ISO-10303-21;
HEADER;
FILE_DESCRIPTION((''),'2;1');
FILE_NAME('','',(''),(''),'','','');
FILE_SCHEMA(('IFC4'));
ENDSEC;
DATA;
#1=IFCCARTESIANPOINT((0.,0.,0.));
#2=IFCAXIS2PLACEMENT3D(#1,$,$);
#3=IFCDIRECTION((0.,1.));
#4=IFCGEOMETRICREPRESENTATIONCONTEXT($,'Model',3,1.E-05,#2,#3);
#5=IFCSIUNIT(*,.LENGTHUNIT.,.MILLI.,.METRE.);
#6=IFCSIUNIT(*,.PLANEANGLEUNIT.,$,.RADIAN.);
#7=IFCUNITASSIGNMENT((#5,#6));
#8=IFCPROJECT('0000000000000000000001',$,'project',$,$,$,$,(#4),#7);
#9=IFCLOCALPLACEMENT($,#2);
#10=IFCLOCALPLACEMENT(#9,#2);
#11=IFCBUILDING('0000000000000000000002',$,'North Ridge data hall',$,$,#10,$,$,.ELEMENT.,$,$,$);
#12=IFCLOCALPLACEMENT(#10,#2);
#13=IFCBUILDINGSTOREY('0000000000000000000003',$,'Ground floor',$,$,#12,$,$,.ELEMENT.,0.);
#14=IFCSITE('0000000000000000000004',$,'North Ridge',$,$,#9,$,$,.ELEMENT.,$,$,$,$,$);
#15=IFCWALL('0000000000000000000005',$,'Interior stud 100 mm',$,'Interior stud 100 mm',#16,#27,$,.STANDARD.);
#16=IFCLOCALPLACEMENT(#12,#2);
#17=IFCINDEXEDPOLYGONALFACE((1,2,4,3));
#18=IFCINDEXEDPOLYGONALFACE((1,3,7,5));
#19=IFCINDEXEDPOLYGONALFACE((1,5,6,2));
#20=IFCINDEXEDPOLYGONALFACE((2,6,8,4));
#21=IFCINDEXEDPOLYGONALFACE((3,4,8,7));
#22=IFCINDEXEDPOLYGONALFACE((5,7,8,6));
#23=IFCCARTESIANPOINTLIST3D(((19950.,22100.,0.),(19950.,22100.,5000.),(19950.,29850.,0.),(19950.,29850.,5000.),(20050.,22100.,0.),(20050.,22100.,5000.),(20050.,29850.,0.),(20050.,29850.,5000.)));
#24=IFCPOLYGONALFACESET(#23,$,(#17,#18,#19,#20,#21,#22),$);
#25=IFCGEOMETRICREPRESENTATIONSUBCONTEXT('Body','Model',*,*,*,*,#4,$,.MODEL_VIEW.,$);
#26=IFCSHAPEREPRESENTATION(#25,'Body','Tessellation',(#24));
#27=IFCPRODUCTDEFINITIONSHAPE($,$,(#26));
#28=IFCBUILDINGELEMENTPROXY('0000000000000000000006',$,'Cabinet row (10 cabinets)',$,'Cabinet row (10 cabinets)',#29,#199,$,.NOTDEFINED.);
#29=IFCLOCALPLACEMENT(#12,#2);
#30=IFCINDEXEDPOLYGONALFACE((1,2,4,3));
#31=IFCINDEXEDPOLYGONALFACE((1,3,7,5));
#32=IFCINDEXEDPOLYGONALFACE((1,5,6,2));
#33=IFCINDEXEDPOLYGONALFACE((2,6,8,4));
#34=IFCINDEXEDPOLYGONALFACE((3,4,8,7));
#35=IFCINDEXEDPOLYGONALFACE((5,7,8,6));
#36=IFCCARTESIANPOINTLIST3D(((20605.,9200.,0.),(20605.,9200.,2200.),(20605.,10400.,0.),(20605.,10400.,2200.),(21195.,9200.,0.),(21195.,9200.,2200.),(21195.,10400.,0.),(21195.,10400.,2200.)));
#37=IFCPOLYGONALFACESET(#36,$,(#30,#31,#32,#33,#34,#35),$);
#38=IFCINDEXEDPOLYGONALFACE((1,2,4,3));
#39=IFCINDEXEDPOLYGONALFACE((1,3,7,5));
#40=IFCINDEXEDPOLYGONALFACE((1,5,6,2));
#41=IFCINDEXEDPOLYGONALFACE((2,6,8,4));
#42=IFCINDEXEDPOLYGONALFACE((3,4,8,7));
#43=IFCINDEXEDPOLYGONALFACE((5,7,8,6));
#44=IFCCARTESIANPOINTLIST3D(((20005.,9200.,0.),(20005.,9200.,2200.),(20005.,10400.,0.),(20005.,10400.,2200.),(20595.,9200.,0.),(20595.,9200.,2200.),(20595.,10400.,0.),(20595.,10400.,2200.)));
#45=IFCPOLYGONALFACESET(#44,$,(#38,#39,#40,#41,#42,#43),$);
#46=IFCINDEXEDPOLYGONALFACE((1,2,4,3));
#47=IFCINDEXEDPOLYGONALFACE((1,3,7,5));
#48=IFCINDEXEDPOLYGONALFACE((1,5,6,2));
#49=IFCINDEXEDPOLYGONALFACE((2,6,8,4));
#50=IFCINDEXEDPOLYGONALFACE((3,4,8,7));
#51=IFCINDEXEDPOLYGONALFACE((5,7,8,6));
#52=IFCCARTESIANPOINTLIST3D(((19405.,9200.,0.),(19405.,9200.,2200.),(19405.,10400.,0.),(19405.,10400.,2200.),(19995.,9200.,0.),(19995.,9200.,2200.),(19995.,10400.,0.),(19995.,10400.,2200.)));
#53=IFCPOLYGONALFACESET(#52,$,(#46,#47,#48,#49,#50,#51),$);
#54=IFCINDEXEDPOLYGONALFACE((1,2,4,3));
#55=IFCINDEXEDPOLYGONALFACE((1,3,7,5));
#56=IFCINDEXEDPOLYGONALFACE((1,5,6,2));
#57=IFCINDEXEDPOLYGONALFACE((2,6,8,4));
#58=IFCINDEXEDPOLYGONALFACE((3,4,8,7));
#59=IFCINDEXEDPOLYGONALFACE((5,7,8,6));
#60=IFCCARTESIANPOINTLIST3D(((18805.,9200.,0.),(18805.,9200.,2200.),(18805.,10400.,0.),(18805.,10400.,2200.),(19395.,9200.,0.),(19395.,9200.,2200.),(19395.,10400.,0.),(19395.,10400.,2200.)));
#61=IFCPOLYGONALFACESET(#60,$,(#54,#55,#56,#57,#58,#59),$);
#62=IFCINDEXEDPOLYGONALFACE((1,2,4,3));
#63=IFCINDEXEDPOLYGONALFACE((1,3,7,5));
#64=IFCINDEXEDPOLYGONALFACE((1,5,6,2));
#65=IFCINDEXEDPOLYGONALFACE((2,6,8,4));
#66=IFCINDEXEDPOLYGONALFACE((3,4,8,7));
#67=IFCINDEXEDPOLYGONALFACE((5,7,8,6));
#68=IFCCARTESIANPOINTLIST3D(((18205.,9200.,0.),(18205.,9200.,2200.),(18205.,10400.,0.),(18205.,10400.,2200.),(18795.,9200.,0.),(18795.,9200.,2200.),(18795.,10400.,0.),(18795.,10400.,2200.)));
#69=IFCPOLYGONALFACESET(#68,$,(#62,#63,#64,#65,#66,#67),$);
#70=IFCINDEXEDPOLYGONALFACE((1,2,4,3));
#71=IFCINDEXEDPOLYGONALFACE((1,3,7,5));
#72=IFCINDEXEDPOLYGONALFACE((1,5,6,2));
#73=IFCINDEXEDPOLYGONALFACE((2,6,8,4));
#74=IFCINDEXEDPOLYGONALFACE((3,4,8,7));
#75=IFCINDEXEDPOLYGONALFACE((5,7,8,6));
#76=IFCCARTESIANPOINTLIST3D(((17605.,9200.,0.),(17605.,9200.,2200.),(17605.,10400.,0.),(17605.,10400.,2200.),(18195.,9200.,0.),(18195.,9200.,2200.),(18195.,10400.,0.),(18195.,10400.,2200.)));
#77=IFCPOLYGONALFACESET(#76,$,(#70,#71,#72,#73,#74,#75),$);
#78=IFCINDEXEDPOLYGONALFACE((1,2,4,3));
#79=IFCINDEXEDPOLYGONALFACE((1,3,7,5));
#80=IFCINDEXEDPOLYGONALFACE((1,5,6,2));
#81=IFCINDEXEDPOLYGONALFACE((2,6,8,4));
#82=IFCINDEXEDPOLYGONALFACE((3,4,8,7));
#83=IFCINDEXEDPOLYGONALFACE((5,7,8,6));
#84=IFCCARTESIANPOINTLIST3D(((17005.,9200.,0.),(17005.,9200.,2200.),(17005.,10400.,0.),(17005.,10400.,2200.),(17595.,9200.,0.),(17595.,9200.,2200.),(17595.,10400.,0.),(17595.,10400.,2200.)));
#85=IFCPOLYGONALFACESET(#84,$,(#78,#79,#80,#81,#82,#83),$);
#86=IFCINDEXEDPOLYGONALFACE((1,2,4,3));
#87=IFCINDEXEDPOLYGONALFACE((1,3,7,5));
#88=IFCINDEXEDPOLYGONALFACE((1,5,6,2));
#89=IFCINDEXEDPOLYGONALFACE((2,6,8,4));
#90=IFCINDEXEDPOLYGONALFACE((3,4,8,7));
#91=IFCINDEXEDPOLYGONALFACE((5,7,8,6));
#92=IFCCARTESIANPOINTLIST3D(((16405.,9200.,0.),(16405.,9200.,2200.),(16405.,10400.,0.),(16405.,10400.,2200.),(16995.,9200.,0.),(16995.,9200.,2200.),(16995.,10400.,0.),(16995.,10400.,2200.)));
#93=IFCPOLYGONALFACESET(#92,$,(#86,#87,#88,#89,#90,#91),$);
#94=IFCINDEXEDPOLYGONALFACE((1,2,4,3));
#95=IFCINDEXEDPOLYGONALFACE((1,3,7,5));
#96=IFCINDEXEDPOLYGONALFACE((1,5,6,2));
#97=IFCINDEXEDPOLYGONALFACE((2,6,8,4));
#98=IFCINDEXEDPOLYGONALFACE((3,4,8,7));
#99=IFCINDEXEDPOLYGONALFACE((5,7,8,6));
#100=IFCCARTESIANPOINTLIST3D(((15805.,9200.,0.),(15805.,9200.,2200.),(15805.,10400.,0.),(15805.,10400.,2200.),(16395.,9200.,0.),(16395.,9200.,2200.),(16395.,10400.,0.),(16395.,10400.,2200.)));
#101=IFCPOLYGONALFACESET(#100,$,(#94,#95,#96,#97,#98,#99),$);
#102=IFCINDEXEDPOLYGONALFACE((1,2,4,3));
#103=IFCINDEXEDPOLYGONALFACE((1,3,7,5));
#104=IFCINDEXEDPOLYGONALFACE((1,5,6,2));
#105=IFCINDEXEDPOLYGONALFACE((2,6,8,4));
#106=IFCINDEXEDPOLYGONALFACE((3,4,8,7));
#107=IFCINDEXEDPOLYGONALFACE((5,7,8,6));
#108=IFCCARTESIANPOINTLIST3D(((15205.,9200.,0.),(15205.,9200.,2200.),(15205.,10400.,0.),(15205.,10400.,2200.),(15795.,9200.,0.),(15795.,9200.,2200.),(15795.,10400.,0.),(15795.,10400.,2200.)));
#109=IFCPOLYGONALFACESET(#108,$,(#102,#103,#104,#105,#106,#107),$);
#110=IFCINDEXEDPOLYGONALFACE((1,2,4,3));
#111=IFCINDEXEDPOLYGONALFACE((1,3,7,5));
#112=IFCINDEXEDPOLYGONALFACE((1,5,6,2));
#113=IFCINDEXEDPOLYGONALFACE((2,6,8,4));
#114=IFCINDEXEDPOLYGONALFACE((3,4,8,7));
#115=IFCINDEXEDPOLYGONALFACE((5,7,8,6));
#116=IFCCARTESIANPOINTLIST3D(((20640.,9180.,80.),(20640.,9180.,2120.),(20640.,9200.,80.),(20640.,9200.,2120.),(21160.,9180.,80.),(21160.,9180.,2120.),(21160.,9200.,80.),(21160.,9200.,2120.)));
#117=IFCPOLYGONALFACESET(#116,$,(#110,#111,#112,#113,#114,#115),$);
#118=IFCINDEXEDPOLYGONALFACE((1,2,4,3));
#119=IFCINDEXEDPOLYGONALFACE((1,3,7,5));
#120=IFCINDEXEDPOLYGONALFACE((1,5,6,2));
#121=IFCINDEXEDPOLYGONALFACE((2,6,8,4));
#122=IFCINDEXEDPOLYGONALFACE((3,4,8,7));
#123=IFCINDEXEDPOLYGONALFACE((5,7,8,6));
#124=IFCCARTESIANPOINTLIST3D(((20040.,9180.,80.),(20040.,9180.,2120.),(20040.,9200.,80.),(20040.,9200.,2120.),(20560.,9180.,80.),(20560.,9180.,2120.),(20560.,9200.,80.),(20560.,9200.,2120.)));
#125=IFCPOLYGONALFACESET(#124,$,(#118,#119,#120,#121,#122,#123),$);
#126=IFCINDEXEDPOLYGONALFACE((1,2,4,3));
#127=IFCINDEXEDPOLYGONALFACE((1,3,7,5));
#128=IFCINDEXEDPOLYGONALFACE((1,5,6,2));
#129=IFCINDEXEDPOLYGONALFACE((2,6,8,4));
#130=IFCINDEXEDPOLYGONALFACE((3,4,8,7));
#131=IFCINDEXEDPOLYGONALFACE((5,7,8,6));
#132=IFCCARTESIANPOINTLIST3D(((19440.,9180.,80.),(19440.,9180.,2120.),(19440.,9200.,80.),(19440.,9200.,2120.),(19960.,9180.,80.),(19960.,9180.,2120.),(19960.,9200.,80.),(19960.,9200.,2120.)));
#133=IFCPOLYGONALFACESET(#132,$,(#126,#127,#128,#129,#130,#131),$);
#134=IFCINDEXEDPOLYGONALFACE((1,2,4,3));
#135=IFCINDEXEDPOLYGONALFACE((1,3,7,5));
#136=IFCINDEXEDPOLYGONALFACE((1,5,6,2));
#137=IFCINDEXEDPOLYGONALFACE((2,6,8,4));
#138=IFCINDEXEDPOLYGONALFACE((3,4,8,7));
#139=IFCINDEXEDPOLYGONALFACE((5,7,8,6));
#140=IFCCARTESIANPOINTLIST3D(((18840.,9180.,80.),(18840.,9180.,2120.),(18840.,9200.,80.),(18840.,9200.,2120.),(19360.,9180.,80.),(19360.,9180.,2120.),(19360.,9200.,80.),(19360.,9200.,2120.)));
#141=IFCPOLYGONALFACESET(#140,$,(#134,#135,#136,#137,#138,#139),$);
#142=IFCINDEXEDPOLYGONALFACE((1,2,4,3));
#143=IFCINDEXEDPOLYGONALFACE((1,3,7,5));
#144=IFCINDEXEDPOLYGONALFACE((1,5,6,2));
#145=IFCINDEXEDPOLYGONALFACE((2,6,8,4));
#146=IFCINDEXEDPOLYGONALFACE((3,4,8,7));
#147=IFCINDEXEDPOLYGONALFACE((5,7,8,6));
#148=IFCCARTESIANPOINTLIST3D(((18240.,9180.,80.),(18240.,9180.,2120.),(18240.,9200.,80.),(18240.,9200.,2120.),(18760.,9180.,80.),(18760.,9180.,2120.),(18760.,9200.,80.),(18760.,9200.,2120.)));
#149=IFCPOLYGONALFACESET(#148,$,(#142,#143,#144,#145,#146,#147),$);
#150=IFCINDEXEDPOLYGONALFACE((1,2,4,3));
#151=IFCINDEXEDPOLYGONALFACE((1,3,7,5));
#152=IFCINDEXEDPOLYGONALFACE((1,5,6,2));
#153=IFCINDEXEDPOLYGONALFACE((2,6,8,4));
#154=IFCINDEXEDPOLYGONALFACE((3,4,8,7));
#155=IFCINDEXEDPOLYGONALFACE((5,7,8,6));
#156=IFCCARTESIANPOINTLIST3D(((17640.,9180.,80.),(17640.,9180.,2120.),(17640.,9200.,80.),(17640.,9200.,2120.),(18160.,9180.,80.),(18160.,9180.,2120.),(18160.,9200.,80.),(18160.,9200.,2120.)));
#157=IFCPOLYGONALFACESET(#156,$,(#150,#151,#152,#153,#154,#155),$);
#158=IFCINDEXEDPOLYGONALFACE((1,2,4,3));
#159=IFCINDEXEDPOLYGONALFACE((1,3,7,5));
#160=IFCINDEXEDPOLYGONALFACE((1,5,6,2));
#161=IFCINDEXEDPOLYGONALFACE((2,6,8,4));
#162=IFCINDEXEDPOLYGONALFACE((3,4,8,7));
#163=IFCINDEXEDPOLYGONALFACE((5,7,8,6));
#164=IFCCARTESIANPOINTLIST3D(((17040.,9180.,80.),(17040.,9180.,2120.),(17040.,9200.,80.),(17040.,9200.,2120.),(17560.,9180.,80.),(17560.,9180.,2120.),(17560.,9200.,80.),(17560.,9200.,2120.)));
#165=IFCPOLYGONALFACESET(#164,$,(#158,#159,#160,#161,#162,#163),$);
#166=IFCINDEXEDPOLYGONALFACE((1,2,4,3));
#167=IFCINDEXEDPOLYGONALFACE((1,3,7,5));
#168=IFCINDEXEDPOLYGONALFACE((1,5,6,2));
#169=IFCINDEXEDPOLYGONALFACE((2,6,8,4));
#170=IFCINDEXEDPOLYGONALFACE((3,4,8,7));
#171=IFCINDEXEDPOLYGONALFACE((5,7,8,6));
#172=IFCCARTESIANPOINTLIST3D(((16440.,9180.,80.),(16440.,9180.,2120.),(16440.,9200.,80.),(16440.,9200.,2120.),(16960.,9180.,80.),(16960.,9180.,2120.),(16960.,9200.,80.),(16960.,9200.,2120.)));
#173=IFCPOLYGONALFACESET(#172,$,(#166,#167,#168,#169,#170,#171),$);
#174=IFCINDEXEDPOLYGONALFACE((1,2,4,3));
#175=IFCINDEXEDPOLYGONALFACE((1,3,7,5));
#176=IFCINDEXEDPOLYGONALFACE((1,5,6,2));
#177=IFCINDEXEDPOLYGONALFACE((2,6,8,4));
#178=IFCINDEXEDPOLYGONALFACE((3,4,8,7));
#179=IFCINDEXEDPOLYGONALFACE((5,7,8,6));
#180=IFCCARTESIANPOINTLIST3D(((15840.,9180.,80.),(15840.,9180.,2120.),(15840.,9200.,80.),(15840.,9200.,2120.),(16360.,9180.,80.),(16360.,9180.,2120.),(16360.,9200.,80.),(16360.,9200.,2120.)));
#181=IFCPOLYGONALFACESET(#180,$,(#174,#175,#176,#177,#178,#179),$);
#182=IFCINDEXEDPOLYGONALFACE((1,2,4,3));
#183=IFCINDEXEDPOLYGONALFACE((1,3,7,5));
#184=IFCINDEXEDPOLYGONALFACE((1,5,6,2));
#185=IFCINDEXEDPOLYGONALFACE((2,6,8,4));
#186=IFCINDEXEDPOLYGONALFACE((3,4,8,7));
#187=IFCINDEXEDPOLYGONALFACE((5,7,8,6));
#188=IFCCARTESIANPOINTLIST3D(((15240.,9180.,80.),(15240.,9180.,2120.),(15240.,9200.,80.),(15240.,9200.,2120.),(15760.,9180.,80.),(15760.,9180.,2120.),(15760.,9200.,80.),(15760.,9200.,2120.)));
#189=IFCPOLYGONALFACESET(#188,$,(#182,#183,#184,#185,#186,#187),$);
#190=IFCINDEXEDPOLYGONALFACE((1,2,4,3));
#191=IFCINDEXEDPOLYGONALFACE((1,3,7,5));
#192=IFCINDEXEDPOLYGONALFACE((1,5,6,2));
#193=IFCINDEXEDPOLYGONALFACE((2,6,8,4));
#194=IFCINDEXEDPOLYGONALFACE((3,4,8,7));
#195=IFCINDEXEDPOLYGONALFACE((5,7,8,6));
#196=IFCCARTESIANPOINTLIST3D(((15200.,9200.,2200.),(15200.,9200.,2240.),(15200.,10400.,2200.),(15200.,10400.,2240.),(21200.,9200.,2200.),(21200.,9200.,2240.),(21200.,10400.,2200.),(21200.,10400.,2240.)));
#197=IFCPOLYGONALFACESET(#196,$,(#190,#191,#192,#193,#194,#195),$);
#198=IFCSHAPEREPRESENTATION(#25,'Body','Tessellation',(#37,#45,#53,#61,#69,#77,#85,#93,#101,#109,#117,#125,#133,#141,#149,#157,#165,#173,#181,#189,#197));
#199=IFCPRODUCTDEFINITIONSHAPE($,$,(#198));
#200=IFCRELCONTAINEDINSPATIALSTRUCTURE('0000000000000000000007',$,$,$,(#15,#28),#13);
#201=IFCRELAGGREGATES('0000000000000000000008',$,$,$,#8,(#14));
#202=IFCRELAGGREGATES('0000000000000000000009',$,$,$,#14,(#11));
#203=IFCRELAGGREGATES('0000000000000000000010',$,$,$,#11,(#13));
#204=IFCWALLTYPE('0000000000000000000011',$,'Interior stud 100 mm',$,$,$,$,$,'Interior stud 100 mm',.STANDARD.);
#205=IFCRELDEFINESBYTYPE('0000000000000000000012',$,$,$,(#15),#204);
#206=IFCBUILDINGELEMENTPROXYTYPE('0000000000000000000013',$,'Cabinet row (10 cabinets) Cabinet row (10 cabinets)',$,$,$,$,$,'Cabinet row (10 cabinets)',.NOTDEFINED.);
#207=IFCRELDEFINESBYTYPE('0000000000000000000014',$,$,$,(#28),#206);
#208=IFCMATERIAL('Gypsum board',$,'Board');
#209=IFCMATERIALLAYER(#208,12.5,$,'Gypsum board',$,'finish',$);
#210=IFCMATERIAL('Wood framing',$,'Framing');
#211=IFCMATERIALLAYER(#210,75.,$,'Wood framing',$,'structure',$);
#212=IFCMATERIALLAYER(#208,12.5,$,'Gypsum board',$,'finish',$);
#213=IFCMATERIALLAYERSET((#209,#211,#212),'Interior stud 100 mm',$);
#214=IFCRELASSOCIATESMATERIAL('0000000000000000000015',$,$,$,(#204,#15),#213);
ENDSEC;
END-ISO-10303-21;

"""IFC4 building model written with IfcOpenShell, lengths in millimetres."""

from ifc_helpers import new_model, si_unit, direction, frame, origin, place, context, subcontext, project, spatial, polyline, outline, extrude, source, transform, mapped, material, layer, layer_set, layer_usage, type_object, type_shapes, element, save


model = new_model("IFC4")

# Units and contexts
model_context = context("Model", 3, precision=1e-05, world=origin(), true_north=direction((0.0, 1.0)))
body_context = subcontext(model_context, "Body", "Model", "MODEL_VIEW")
ifc_project = project(units=[si_unit("LENGTHUNIT", "METRE", prefix="MILLI"), si_unit("PLANEANGLEUNIT", "RADIAN")], contexts=[model_context])

# Site, building, storey
site_placement = place(None, origin())
site = spatial("IfcSite", under=ifc_project, at=site_placement, Name="North Ridge", CompositionType="ELEMENT")
building_placement = place(site_placement, origin())
building = spatial("IfcBuilding", under=site, at=building_placement, Name="North Ridge data hall", CompositionType="ELEMENT")
storey_placement = place(building_placement, origin())
storey = spatial("IfcBuildingStorey", under=building, at=storey_placement, Name="Ground floor", CompositionType="ELEMENT", Elevation=0.0)

# Wall
ifc_material_1 = material(Name="Gypsum board", Category="Board")
ifc_layer_1 = layer(ifc_material_1, 12.5, Name="Gypsum board", Category="finish")
ifc_material_2 = material(Name="Wood framing", Category="Framing")
ifc_layer_2 = layer(ifc_material_2, 75.0, Name="Wood framing", Category="structure")
ifc_layer_3 = layer(ifc_material_1, 12.5, Name="Gypsum board", Category="finish")
ifc_layer_set = layer_set([ifc_layer_1, ifc_layer_2, ifc_layer_3], Name="Interior stud 100 mm")
ifc_layer_usage = layer_usage(ifc_layer_set, "AXIS2", "NEGATIVE", 50.0)
wall_type = type_object("IfcWallType", Name="Interior stud 100 mm", ElementType="Interior stud 100 mm", PredefinedType="STANDARD", material=ifc_layer_set)
wall_placement = place(storey_placement, frame((20000.0, 22000.0, 0.0), z_axis=(0.0, 0.0, 1.0), x_axis=(0.0, 1.0, 0.0)))
element("IfcWall", 1, at=wall_placement, inside=storey, type_object=wall_type, material=ifc_layer_usage, Name="Interior stud 100 mm", ObjectType="Interior stud 100 mm", PredefinedType="STANDARD", context=body_context, shape_type="SweptSolid", body=[
    extrude(outline(polyline([(100.0, -50.0), (7850.0, -50.0), (7850.0, 50.0), (100.0, 50.0), (100.0, -50.0)])), origin(), (0.0, 0.0, 1.0), 5000.0),
])

# Building element proxy
building_element_proxy_type_1 = type_object("IfcBuildingElementProxyType", Name="Cabinet row (10 cabinets) Cabinet row (10 cabinets)", ElementType="Cabinet row (10 cabinets)", PredefinedType="NOTDEFINED")
shared_shape_1 = source(origin(), body_context, "Body", "SweptSolid", [
    extrude(outline(polyline([(5.0, 0.0), (595.0, 0.0), (595.0, 1200.0), (5.0, 1200.0), (5.0, 0.0)])), origin(), (0.0, 0.0, 1.0), 2200.0),
    extrude(outline(polyline([(605.0, 0.0), (1195.0, 0.0), (1195.0, 1200.0), (605.0, 1200.0), (605.0, 0.0)])), origin(), (0.0, 0.0, 1.0), 2200.0),
    extrude(outline(polyline([(1205.0, 0.0), (1795.0, 0.0), (1795.0, 1200.0), (1205.0, 1200.0), (1205.0, 0.0)])), origin(), (0.0, 0.0, 1.0), 2200.0),
    extrude(outline(polyline([(1805.0, 0.0), (2395.0, 0.0), (2395.0, 1200.0), (1805.0, 1200.0), (1805.0, 0.0)])), origin(), (0.0, 0.0, 1.0), 2200.0),
    extrude(outline(polyline([(2405.0, 0.0), (2995.0, 0.0), (2995.0, 1200.0), (2405.0, 1200.0), (2405.0, 0.0)])), origin(), (0.0, 0.0, 1.0), 2200.0),
    extrude(outline(polyline([(3005.0, 0.0), (3595.0, 0.0), (3595.0, 1200.0), (3005.0, 1200.0), (3005.0, 0.0)])), origin(), (0.0, 0.0, 1.0), 2200.0),
    extrude(outline(polyline([(3605.0, 0.0), (4195.0, 0.0), (4195.0, 1200.0), (3605.0, 1200.0), (3605.0, 0.0)])), origin(), (0.0, 0.0, 1.0), 2200.0),
    extrude(outline(polyline([(4205.0, 0.0), (4795.0, 0.0), (4795.0, 1200.0), (4205.0, 1200.0), (4205.0, 0.0)])), origin(), (0.0, 0.0, 1.0), 2200.0),
    extrude(outline(polyline([(4805.0, 0.0), (5395.0, 0.0), (5395.0, 1200.0), (4805.0, 1200.0), (4805.0, 0.0)])), origin(), (0.0, 0.0, 1.0), 2200.0),
    extrude(outline(polyline([(5405.0, 0.0), (5995.0, 0.0), (5995.0, 1200.0), (5405.0, 1200.0), (5405.0, 0.0)])), origin(), (0.0, 0.0, 1.0), 2200.0),
    extrude(outline(polyline([(40.0, 1200.0), (560.0, 1200.0), (560.0, 1220.0), (40.0, 1220.0), (40.0, 1200.0)])), frame((0.0, 0.0, 80.0)), (0.0, 0.0, 1.0), 2040.0),
    extrude(outline(polyline([(640.0, 1200.0), (1160.0, 1200.0), (1160.0, 1220.0), (640.0, 1220.0), (640.0, 1200.0)])), frame((0.0, 0.0, 80.0)), (0.0, 0.0, 1.0), 2040.0),
    extrude(outline(polyline([(1240.0, 1200.0), (1760.0, 1200.0), (1760.0, 1220.0), (1240.0, 1220.0), (1240.0, 1200.0)])), frame((0.0, 0.0, 80.0)), (0.0, 0.0, 1.0), 2040.0),
    extrude(outline(polyline([(1840.0, 1200.0), (2360.0, 1200.0), (2360.0, 1220.0), (1840.0, 1220.0), (1840.0, 1200.0)])), frame((0.0, 0.0, 80.0)), (0.0, 0.0, 1.0), 2040.0),
    extrude(outline(polyline([(2440.0, 1200.0), (2960.0, 1200.0), (2960.0, 1220.0), (2440.0, 1220.0), (2440.0, 1200.0)])), frame((0.0, 0.0, 80.0)), (0.0, 0.0, 1.0), 2040.0),
    extrude(outline(polyline([(3040.0, 1200.0), (3560.0, 1200.0), (3560.0, 1220.0), (3040.0, 1220.0), (3040.0, 1200.0)])), frame((0.0, 0.0, 80.0)), (0.0, 0.0, 1.0), 2040.0),
    extrude(outline(polyline([(3640.0, 1200.0), (4160.0, 1200.0), (4160.0, 1220.0), (3640.0, 1220.0), (3640.0, 1200.0)])), frame((0.0, 0.0, 80.0)), (0.0, 0.0, 1.0), 2040.0),
    extrude(outline(polyline([(4240.0, 1200.0), (4760.0, 1200.0), (4760.0, 1220.0), (4240.0, 1220.0), (4240.0, 1200.0)])), frame((0.0, 0.0, 80.0)), (0.0, 0.0, 1.0), 2040.0),
    extrude(outline(polyline([(4840.0, 1200.0), (5360.0, 1200.0), (5360.0, 1220.0), (4840.0, 1220.0), (4840.0, 1200.0)])), frame((0.0, 0.0, 80.0)), (0.0, 0.0, 1.0), 2040.0),
    extrude(outline(polyline([(5440.0, 1200.0), (5960.0, 1200.0), (5960.0, 1220.0), (5440.0, 1220.0), (5440.0, 1200.0)])), frame((0.0, 0.0, 80.0)), (0.0, 0.0, 1.0), 2040.0),
    extrude(outline(polyline([(0.0, 0.0), (6000.0, 0.0), (6000.0, 1200.0), (0.0, 1200.0), (0.0, 0.0)])), frame((0.0, 0.0, 2200.0)), (0.0, 0.0, 1.0), 40.0),
])
type_shapes(building_element_proxy_type_1, [shared_shape_1])
for number, where, z_axis, x_axis, name in (
    (2, (21200.0, 10400.0, 0.0), (0.0, 0.0, 1.0), (-1.0, 0.0, 0.0), "Cabinet row (10 cabinets)"),
):
    element("IfcBuildingElementProxy", number, at=place(storey_placement, frame(where, z_axis=z_axis, x_axis=x_axis)), inside=storey, type_object=building_element_proxy_type_1, Name=name, ObjectType="Cabinet row (10 cabinets)", PredefinedType="NOTDEFINED", context=body_context, shape_type="MappedRepresentation", body=[
        mapped(shared_shape_1, transform((0.0, 0.0, 0.0))),
    ])

save(model, "model.ifc")
